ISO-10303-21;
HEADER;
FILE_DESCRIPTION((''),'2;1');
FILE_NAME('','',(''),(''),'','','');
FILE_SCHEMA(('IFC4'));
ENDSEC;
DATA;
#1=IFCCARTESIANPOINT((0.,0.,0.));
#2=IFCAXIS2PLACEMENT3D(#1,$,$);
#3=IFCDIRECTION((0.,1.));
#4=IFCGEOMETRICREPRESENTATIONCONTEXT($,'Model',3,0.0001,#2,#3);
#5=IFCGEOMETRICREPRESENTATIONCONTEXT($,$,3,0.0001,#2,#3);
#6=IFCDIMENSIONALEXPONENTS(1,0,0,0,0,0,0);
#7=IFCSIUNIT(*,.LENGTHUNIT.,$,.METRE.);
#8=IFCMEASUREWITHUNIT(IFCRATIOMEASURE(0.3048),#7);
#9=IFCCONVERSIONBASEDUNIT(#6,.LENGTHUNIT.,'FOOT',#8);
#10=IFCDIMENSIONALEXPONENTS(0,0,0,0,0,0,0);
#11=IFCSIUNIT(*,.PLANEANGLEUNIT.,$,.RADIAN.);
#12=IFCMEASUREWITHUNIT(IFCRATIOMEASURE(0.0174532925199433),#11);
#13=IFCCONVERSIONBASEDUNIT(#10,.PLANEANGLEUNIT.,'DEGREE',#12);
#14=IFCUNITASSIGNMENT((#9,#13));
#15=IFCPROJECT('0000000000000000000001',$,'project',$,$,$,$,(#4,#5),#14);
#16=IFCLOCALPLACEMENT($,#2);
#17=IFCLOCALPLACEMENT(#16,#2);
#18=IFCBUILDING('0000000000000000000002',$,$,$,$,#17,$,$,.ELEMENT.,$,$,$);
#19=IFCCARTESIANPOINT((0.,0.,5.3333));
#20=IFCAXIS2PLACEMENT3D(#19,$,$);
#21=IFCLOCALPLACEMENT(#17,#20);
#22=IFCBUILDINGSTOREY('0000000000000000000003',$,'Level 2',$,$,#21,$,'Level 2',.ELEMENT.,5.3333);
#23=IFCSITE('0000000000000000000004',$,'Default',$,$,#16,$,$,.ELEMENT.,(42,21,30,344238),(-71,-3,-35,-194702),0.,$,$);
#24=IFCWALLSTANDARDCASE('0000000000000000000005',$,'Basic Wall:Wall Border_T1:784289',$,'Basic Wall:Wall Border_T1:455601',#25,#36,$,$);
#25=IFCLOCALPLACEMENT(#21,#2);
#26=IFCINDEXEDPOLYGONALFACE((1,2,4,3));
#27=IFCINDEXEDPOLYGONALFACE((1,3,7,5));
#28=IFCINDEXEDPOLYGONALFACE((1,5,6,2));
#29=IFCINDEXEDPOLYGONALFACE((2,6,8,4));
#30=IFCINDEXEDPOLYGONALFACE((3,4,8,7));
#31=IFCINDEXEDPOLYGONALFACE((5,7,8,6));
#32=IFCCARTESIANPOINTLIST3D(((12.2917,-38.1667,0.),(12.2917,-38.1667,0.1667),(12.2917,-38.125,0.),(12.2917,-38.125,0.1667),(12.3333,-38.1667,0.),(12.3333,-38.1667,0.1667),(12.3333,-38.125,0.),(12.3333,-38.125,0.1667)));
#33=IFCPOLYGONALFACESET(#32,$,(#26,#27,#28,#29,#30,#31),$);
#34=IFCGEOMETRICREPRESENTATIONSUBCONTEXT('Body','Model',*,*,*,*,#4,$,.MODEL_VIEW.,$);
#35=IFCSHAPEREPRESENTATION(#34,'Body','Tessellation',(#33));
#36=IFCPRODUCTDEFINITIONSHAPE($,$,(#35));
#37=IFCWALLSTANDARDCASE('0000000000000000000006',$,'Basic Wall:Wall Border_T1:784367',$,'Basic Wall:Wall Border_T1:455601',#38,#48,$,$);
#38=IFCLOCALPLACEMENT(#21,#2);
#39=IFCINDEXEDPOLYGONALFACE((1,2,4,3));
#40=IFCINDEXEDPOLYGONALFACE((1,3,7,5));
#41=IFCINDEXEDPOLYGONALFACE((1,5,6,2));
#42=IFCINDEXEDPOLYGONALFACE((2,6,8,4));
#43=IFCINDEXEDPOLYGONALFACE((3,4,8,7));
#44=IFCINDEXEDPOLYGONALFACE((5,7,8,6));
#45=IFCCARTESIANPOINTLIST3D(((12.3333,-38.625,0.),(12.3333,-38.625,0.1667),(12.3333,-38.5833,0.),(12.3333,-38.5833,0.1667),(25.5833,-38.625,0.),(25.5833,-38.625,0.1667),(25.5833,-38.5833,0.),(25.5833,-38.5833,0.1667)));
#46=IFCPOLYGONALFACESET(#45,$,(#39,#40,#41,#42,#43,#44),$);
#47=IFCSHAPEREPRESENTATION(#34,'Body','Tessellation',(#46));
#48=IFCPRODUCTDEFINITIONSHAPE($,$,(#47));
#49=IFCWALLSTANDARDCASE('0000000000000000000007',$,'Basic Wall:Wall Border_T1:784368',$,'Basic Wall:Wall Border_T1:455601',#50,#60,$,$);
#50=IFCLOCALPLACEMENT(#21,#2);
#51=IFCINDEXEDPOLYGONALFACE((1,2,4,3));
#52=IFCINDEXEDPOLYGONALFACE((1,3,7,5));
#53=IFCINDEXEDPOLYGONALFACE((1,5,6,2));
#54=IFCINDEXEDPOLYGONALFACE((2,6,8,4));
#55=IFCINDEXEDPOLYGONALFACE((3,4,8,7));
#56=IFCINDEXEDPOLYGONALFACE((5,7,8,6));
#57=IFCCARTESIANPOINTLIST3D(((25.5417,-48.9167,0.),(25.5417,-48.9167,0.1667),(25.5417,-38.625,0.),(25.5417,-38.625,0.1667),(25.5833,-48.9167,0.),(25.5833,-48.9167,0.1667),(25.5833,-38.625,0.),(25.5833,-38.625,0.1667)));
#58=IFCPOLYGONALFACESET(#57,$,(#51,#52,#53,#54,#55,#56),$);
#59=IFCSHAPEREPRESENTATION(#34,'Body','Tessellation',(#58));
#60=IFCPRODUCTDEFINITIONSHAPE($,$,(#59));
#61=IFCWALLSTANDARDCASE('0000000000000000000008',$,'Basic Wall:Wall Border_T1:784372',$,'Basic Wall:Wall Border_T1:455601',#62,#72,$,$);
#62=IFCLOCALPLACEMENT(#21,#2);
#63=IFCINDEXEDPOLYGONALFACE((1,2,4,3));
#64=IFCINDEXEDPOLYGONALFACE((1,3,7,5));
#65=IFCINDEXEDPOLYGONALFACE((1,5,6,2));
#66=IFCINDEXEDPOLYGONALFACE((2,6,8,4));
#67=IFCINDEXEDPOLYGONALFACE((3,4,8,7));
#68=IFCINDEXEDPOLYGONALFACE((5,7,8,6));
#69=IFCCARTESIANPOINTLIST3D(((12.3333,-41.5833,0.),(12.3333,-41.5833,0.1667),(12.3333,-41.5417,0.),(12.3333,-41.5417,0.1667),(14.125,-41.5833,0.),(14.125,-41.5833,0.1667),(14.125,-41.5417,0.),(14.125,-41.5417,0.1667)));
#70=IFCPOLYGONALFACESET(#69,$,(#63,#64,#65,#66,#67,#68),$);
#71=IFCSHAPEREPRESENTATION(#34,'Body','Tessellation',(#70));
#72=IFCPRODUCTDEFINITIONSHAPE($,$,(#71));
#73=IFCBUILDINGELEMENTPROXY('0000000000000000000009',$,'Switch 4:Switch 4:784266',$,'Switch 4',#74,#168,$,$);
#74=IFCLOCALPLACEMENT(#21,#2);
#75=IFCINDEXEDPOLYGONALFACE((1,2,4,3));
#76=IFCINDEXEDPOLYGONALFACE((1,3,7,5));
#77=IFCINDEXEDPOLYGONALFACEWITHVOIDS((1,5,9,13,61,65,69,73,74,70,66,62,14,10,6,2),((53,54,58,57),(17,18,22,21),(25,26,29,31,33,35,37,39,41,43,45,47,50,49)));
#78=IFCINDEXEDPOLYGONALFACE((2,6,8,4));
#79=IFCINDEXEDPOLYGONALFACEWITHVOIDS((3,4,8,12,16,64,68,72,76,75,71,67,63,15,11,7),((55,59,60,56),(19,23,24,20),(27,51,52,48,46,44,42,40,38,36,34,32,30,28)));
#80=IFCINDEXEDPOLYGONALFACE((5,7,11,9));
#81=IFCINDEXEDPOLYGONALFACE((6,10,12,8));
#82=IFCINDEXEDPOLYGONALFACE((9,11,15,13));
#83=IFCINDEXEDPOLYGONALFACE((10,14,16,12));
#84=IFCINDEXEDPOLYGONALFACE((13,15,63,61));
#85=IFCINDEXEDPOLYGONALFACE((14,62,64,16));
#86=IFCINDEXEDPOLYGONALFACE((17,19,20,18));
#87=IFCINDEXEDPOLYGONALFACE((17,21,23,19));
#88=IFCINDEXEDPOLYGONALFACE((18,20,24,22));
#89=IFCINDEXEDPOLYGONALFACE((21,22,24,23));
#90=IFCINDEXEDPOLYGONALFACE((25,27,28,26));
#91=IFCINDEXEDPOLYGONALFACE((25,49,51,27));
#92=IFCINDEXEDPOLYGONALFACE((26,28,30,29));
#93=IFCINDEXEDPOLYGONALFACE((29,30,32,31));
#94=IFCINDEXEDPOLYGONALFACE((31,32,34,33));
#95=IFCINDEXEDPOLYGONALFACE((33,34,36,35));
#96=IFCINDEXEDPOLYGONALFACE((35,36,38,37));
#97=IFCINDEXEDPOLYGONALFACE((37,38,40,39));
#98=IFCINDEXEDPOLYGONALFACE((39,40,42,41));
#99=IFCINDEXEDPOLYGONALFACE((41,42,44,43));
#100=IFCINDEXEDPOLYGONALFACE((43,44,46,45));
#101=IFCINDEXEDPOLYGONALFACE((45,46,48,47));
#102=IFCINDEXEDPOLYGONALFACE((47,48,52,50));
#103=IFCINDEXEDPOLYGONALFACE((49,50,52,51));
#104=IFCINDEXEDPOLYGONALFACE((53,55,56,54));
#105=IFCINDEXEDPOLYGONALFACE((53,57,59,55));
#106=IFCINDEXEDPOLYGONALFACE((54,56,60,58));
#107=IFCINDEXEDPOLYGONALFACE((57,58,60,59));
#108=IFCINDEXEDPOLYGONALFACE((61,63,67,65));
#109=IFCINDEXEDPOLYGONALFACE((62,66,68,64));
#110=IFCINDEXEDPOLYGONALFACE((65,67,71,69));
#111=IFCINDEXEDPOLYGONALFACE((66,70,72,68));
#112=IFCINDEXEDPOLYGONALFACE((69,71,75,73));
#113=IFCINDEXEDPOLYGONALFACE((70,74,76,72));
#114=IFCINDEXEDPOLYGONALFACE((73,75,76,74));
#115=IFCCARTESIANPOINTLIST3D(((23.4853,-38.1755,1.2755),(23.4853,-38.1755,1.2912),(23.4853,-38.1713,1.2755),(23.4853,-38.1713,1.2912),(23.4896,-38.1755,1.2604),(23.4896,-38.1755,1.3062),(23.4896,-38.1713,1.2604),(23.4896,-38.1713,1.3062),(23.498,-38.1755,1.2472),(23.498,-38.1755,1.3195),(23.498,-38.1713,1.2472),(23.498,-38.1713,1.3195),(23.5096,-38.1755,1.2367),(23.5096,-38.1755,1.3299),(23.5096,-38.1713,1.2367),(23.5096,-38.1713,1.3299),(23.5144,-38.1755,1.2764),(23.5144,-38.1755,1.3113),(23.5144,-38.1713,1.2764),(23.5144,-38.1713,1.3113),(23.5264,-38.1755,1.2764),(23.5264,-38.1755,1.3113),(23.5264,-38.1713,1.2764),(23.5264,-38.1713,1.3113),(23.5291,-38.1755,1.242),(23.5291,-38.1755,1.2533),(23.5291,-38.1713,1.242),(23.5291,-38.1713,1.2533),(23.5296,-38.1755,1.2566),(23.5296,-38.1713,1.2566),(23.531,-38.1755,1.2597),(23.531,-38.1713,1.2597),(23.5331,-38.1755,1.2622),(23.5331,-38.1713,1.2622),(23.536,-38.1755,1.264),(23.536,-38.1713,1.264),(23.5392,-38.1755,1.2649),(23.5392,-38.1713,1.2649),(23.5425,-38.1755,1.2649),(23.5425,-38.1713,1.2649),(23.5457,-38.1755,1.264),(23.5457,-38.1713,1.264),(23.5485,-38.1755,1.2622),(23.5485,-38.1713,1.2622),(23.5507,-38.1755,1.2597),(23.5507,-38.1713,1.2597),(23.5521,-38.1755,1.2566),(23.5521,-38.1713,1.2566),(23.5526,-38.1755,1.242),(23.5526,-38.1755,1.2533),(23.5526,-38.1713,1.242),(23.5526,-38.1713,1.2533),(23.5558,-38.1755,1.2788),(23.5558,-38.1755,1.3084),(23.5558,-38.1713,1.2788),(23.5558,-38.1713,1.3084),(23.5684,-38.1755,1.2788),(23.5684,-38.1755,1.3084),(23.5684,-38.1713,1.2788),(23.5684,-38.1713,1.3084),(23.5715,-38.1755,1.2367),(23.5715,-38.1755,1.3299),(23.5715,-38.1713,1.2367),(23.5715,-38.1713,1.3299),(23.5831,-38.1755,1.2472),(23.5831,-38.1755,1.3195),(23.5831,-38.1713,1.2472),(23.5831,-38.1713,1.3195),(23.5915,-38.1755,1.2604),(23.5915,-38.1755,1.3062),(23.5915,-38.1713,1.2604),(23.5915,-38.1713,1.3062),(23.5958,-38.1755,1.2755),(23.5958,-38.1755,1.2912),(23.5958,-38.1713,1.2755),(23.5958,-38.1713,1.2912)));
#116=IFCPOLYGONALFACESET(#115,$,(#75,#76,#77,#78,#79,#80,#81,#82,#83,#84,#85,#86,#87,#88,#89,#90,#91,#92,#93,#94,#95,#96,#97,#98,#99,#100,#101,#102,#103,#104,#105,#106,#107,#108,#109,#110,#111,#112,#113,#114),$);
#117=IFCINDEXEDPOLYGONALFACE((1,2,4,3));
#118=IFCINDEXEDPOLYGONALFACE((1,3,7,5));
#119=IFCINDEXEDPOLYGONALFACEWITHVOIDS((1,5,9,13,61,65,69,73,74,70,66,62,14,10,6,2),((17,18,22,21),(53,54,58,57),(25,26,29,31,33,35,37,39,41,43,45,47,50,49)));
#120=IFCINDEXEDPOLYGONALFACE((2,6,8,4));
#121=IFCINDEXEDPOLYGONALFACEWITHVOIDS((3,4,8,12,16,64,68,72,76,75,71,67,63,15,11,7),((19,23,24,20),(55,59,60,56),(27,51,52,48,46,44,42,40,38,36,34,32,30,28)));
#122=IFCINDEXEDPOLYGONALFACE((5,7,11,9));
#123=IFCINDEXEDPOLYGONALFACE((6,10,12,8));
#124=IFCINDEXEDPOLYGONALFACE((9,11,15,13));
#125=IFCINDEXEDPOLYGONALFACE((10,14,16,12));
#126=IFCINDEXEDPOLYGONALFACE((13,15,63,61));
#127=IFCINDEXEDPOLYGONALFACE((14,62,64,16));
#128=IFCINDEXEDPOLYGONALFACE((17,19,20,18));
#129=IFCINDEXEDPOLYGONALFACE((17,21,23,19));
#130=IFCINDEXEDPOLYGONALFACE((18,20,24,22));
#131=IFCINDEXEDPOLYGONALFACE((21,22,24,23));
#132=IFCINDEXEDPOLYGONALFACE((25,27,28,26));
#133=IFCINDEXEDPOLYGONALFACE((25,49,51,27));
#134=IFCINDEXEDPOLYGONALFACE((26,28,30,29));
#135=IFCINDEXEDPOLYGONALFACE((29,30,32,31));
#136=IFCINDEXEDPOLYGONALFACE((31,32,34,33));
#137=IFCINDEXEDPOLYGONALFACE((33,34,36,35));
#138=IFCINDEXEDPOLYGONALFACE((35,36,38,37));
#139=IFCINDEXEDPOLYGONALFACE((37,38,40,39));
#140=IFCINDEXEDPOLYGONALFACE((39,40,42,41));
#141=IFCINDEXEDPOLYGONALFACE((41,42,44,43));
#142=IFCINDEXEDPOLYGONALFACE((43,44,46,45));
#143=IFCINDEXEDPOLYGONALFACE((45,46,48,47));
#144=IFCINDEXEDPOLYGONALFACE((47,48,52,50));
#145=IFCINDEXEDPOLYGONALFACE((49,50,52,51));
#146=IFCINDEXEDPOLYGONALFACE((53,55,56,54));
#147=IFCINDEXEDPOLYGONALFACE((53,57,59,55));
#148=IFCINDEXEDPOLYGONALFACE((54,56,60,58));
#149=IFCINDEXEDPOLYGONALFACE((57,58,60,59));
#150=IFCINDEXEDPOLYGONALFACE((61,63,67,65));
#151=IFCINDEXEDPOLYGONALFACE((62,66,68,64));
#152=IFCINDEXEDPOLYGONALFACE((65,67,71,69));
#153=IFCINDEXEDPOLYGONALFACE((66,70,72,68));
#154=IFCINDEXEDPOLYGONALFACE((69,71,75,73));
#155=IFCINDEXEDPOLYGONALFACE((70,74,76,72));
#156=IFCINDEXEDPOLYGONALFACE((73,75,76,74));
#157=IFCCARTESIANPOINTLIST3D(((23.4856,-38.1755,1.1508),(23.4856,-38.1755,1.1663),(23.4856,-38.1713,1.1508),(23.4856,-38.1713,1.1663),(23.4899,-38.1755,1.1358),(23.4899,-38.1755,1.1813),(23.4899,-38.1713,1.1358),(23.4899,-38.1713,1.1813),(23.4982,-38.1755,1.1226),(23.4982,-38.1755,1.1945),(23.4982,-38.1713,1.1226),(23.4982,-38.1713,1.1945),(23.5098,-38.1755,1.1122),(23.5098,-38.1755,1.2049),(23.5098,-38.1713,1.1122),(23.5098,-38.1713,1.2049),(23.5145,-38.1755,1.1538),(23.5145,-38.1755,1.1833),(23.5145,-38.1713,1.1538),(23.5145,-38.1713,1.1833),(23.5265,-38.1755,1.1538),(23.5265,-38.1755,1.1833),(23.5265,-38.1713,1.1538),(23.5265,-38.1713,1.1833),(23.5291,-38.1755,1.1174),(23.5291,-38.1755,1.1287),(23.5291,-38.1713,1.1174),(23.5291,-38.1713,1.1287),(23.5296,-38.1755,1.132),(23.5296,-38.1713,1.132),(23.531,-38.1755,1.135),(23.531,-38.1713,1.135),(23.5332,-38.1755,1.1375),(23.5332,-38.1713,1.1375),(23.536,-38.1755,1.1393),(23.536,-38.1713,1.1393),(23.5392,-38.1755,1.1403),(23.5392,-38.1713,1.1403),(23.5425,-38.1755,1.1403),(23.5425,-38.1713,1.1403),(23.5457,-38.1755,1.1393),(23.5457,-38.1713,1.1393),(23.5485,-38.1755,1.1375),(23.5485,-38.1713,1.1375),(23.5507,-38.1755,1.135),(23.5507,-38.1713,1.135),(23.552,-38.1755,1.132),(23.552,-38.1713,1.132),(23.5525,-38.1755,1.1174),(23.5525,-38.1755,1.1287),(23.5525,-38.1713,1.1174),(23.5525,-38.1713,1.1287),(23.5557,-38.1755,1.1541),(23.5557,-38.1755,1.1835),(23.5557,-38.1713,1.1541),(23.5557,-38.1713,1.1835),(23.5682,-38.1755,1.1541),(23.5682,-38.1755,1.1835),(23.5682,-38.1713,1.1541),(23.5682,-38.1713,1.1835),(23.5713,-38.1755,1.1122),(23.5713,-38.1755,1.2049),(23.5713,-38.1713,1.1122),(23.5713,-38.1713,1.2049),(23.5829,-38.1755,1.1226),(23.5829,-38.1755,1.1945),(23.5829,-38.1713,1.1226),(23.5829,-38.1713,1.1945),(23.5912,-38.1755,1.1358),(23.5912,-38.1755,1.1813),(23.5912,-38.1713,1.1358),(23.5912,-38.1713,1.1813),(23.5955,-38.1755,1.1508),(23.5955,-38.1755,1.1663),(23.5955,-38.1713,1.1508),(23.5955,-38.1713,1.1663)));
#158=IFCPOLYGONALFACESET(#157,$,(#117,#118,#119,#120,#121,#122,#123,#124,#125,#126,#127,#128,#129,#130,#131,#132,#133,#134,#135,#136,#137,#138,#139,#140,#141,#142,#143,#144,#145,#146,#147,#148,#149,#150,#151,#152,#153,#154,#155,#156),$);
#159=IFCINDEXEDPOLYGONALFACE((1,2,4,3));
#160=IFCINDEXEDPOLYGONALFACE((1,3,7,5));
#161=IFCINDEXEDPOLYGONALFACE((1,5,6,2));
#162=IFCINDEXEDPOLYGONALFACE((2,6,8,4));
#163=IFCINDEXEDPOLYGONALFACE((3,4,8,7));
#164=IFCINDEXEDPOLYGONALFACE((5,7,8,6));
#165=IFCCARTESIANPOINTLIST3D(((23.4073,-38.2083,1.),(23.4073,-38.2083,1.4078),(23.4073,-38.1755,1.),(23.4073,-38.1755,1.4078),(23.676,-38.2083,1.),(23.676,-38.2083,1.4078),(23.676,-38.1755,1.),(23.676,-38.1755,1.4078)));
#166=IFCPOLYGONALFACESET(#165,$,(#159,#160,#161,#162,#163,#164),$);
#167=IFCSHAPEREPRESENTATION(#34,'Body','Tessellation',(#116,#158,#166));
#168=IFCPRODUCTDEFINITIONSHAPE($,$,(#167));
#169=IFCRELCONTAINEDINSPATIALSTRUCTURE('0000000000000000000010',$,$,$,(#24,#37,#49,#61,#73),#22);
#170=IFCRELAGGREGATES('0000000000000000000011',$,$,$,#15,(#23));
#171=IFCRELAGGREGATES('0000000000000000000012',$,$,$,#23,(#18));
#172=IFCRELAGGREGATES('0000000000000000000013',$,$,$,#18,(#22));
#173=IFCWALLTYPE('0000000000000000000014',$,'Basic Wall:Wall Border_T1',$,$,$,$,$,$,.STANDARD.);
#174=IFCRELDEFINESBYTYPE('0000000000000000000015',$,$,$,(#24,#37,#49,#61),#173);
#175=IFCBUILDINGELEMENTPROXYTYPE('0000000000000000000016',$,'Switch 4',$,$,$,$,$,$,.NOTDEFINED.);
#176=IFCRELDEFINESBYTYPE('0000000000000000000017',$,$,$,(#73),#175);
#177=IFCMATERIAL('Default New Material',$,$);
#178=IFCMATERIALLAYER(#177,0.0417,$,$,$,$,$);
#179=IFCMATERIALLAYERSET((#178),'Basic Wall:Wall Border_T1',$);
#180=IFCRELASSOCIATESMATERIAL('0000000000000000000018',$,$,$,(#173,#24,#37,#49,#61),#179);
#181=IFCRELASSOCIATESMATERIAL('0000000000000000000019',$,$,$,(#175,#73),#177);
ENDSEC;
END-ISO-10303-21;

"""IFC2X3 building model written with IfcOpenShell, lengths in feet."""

from ifc_helpers import new_model, entity, si_unit, converted_unit, direction, frame, frame_2d, origin, origin_2d_with_axis, place, context, subcontext, project, spatial, polyline, circle_curve, parameter, trimmed, segment, composite_curve, rectangle, outline, extrude, source, transform, mapped, material, layer, layer_set, layer_usage, type_object, type_shapes, element, save


model = new_model("IFC2X3")

# Units and contexts
model_context = context("Model", 3, precision=0.0001, world=origin(), true_north=direction((0.0, 1.0)))
context_of_model = context(None, 3, precision=0.0001, world=origin(), true_north=direction((0.0, 1.0)))
body_context = subcontext(model_context, "Body", "Model", "MODEL_VIEW")
ifc_project = project(units=[converted_unit("LENGTHUNIT", "FOOT", entity("IfcRatioMeasure", 0.3048), si_unit("LENGTHUNIT", "METRE"), dimensions=[1, 0, 0, 0, 0, 0, 0]), converted_unit("PLANEANGLEUNIT", "DEGREE", entity("IfcRatioMeasure", 0.0174532925199433), si_unit("PLANEANGLEUNIT", "RADIAN"), dimensions=[0, 0, 0, 0, 0, 0, 0])], contexts=[model_context, context_of_model])

# Site, building, storey
site_placement = place(None, origin())
site = spatial("IfcSite", under=ifc_project, at=site_placement, Name="Default", CompositionType="ELEMENT", RefLatitude=(42, 21, 30, 344238), RefLongitude=(-71, -3, -35, -194702), RefElevation=0.0)
building_placement = place(site_placement, origin())
building = spatial("IfcBuilding", under=site, at=building_placement, CompositionType="ELEMENT")
storey_placement = place(building_placement, frame((0.0, 0.0, 5.3333)))
storey = spatial("IfcBuildingStorey", under=building, at=storey_placement, Name="Level 2", LongName="Level 2", CompositionType="ELEMENT", Elevation=5.3333)

# Shared definitions
ifc_material_1 = material(Name="Default New Material")

# Walls
ifc_layer_1 = layer(ifc_material_1, 0.0417)
ifc_layer_set_1 = layer_set([ifc_layer_1], Name="Basic Wall:Wall Border_T1")
wall_type_1 = type_object("IfcWallType", Name="Basic Wall:Wall Border_T1", PredefinedType="STANDARD", material=ifc_layer_set_1)
ifc_layer_usage_1 = layer_usage(ifc_layer_set_1, "AXIS2", "POSITIVE", -0.0208)
wall_1_placement = place(storey_placement, frame((12.3125, -38.1667, 0.0), z_axis=(0.0, 0.0, 1.0), x_axis=(0.0, 1.0, 0.0)))
element("IfcWallStandardCase", 1, at=wall_1_placement, inside=storey, type_object=wall_type_1, material=ifc_layer_usage_1, Name="Basic Wall:Wall Border_T1:784289", ObjectType="Basic Wall:Wall Border_T1:455601", context=body_context, shape_type="SweptSolid", body=[
    extrude(rectangle(XDim=0.0417, YDim=0.0417, at=frame_2d((0.0208, 0.0), x_axis=(-1.0, 0.0))), origin(), (0.0, 0.0, 1.0), 0.1667),
])
ifc_layer_usage_2 = layer_usage(ifc_layer_set_1, "AXIS2", "POSITIVE", -0.0208)
wall_2_placement = place(storey_placement, frame((12.3333, -38.6042, 0.0)))
element("IfcWallStandardCase", 2, at=wall_2_placement, inside=storey, type_object=wall_type_1, material=ifc_layer_usage_2, Name="Basic Wall:Wall Border_T1:784367", ObjectType="Basic Wall:Wall Border_T1:455601", context=body_context, shape_type="SweptSolid", body=[
    extrude(rectangle(XDim=13.25, YDim=0.0417, at=frame_2d((6.625, 0.0), x_axis=(-1.0, 0.0))), origin(), (0.0, 0.0, 1.0), 0.1667),
])
ifc_layer_usage_3 = layer_usage(ifc_layer_set_1, "AXIS2", "POSITIVE", -0.0208)
wall_3_placement = place(storey_placement, frame((25.5625, -38.625, 0.0), z_axis=(0.0, 0.0, 1.0), x_axis=(0.0, -1.0, 0.0)))
element("IfcWallStandardCase", 3, at=wall_3_placement, inside=storey, type_object=wall_type_1, material=ifc_layer_usage_3, Name="Basic Wall:Wall Border_T1:784368", ObjectType="Basic Wall:Wall Border_T1:455601", context=body_context, shape_type="SweptSolid", body=[
    extrude(rectangle(XDim=10.2917, YDim=0.0417, at=frame_2d((5.1458, 0.0), x_axis=(-1.0, 0.0))), origin(), (0.0, 0.0, 1.0), 0.1667),
])
ifc_layer_usage_4 = layer_usage(ifc_layer_set_1, "AXIS2", "POSITIVE", -0.0208)
wall_4_placement = place(storey_placement, frame((14.125, -41.5625, 0.0), z_axis=(0.0, 0.0, 1.0), x_axis=(-1.0, 0.0, 0.0)))
element("IfcWallStandardCase", 4, at=wall_4_placement, inside=storey, type_object=wall_type_1, material=ifc_layer_usage_4, Name="Basic Wall:Wall Border_T1:784372", ObjectType="Basic Wall:Wall Border_T1:455601", context=body_context, shape_type="SweptSolid", body=[
    extrude(rectangle(XDim=1.7917, YDim=0.0417, at=frame_2d((0.8958, 0.0), x_axis=(-1.0, 0.0))), origin(), (0.0, 0.0, 1.0), 0.1667),
])

# Building element proxy
building_element_proxy_type_1 = type_object("IfcBuildingElementProxyType", Name="Switch 4", PredefinedType="NOTDEFINED", material=ifc_material_1)
shared_shape_1 = source(origin(), body_context, "Body", "SweptSolid", [
    extrude(outline(composite_curve([segment(polyline([(-0.0309, -0.0466), (0.0309, -0.0466)]), True, "CONTINUOUS"), segment(trimmed(circle_curve(frame_2d((-0.0003, 0.0), x_axis=(-1.0, 0.0)), 0.0561), [parameter(123.794741)], [parameter(236.205259)], True, "PARAMETER"), True, "CONTINUOUS"), segment(polyline([(0.0309, 0.0466), (-0.0309, 0.0466)]), True, "CONTINUOUS"), segment(trimmed(circle_curve(frame_2d((0.0003, 0.0), x_axis=(1.0, 0.0)), 0.0561), [parameter(123.794741)], [parameter(236.205259)], True, "PARAMETER"), True, "CONTINUOUS")], self_intersect=False), holes=[polyline([(0.0142, 0.0279), (0.0262, 0.0279), (0.0262, -0.0069), (0.0142, -0.0069), (0.0142, 0.0279)]), polyline([(-0.0153, 0.025), (-0.0153, -0.0045), (-0.0278, -0.0045), (-0.0278, 0.025), (-0.0153, 0.025)]), composite_curve([segment(polyline([(-0.012, -0.0413), (-0.012, -0.03)]), True, "CONTINUOUS"), segment(trimmed(circle_curve(frame_2d((-0.0003, -0.03), x_axis=(-1.0, 0.0)), 0.0117), [parameter(180.0)], [parameter(0.0)], True, "PARAMETER"), False, "CONTINUOUS"), segment(polyline([(0.0115, -0.03), (0.0115, -0.0413)]), True, "CONTINUOUS"), segment(polyline([(0.0115, -0.0413), (-0.012, -0.0413)]), True, "CONTINUOUS")], self_intersect=False)]), frame((-0.0011, 0.0328, 0.2833), z_axis=(0.0, 1.0, 0.0), x_axis=(-1.0, 0.0, 0.0)), (0.0, 0.0, 1.0), 0.0042),
    extrude(outline(composite_curve([segment(polyline([(-0.0308, -0.0464), (0.0308, -0.0464)]), True, "CONTINUOUS"), segment(trimmed(circle_curve(frame_2d((-0.0003, 0.0), x_axis=(-1.0, 0.0)), 0.0558), [parameter(123.794741)], [parameter(236.205259)], True, "PARAMETER"), True, "CONTINUOUS"), segment(polyline([(0.0308, 0.0464), (-0.0308, 0.0464)]), True, "CONTINUOUS"), segment(trimmed(circle_curve(frame_2d((0.0003, 0.0), x_axis=(1.0, 0.0)), 0.0558), [parameter(123.794741)], [parameter(236.205259)], True, "PARAMETER"), True, "CONTINUOUS")], self_intersect=False), holes=[polyline([(0.0141, 0.0247), (0.026, 0.0247), (0.026, -0.0047), (0.0141, -0.0047), (0.0141, 0.0247)]), polyline([(-0.0152, 0.0249), (-0.0152, -0.0045), (-0.0277, -0.0045), (-0.0277, 0.0249), (-0.0152, 0.0249)]), composite_curve([segment(polyline([(-0.012, -0.0411), (-0.012, -0.0299)]), True, "CONTINUOUS"), segment(trimmed(circle_curve(frame_2d((-0.0003, -0.0299), x_axis=(-1.0, 0.0)), 0.0117), [parameter(180.0)], [parameter(0.0)], True, "PARAMETER"), False, "CONTINUOUS"), segment(polyline([(0.0114, -0.0299), (0.0114, -0.0411)]), True, "CONTINUOUS"), segment(polyline([(0.0114, -0.0411), (-0.012, -0.0411)]), True, "CONTINUOUS")], self_intersect=False)]), frame((-0.0011, 0.0328, 0.1586), z_axis=(0.0, 1.0, 0.0), x_axis=(-1.0, 0.0, 0.0)), (0.0, 0.0, 1.0), 0.0042),
    extrude(rectangle(XDim=0.0328, YDim=0.2687, at=origin_2d_with_axis()), frame((0.0, 0.0164, 0.0), z_axis=(0.0, 0.0, 1.0), x_axis=(0.0, -1.0, 0.0)), (0.0, 0.0, 1.0), 0.4078),
])
type_shapes(building_element_proxy_type_1, [shared_shape_1])
for number, where, name in (
    (5, (23.5417, -38.2083, 1.0), "Switch 4:Switch 4:784266"),
):
    element("IfcBuildingElementProxy", number, at=place(storey_placement, frame(where)), inside=storey, type_object=building_element_proxy_type_1, material=ifc_material_1, Name=name, ObjectType="Switch 4", context=body_context, shape_type="MappedRepresentation", body=[
        mapped(shared_shape_1, transform((0.0, 0.0, 0.0), scale=1.0)),
    ])

save(model, "model.ifc")
